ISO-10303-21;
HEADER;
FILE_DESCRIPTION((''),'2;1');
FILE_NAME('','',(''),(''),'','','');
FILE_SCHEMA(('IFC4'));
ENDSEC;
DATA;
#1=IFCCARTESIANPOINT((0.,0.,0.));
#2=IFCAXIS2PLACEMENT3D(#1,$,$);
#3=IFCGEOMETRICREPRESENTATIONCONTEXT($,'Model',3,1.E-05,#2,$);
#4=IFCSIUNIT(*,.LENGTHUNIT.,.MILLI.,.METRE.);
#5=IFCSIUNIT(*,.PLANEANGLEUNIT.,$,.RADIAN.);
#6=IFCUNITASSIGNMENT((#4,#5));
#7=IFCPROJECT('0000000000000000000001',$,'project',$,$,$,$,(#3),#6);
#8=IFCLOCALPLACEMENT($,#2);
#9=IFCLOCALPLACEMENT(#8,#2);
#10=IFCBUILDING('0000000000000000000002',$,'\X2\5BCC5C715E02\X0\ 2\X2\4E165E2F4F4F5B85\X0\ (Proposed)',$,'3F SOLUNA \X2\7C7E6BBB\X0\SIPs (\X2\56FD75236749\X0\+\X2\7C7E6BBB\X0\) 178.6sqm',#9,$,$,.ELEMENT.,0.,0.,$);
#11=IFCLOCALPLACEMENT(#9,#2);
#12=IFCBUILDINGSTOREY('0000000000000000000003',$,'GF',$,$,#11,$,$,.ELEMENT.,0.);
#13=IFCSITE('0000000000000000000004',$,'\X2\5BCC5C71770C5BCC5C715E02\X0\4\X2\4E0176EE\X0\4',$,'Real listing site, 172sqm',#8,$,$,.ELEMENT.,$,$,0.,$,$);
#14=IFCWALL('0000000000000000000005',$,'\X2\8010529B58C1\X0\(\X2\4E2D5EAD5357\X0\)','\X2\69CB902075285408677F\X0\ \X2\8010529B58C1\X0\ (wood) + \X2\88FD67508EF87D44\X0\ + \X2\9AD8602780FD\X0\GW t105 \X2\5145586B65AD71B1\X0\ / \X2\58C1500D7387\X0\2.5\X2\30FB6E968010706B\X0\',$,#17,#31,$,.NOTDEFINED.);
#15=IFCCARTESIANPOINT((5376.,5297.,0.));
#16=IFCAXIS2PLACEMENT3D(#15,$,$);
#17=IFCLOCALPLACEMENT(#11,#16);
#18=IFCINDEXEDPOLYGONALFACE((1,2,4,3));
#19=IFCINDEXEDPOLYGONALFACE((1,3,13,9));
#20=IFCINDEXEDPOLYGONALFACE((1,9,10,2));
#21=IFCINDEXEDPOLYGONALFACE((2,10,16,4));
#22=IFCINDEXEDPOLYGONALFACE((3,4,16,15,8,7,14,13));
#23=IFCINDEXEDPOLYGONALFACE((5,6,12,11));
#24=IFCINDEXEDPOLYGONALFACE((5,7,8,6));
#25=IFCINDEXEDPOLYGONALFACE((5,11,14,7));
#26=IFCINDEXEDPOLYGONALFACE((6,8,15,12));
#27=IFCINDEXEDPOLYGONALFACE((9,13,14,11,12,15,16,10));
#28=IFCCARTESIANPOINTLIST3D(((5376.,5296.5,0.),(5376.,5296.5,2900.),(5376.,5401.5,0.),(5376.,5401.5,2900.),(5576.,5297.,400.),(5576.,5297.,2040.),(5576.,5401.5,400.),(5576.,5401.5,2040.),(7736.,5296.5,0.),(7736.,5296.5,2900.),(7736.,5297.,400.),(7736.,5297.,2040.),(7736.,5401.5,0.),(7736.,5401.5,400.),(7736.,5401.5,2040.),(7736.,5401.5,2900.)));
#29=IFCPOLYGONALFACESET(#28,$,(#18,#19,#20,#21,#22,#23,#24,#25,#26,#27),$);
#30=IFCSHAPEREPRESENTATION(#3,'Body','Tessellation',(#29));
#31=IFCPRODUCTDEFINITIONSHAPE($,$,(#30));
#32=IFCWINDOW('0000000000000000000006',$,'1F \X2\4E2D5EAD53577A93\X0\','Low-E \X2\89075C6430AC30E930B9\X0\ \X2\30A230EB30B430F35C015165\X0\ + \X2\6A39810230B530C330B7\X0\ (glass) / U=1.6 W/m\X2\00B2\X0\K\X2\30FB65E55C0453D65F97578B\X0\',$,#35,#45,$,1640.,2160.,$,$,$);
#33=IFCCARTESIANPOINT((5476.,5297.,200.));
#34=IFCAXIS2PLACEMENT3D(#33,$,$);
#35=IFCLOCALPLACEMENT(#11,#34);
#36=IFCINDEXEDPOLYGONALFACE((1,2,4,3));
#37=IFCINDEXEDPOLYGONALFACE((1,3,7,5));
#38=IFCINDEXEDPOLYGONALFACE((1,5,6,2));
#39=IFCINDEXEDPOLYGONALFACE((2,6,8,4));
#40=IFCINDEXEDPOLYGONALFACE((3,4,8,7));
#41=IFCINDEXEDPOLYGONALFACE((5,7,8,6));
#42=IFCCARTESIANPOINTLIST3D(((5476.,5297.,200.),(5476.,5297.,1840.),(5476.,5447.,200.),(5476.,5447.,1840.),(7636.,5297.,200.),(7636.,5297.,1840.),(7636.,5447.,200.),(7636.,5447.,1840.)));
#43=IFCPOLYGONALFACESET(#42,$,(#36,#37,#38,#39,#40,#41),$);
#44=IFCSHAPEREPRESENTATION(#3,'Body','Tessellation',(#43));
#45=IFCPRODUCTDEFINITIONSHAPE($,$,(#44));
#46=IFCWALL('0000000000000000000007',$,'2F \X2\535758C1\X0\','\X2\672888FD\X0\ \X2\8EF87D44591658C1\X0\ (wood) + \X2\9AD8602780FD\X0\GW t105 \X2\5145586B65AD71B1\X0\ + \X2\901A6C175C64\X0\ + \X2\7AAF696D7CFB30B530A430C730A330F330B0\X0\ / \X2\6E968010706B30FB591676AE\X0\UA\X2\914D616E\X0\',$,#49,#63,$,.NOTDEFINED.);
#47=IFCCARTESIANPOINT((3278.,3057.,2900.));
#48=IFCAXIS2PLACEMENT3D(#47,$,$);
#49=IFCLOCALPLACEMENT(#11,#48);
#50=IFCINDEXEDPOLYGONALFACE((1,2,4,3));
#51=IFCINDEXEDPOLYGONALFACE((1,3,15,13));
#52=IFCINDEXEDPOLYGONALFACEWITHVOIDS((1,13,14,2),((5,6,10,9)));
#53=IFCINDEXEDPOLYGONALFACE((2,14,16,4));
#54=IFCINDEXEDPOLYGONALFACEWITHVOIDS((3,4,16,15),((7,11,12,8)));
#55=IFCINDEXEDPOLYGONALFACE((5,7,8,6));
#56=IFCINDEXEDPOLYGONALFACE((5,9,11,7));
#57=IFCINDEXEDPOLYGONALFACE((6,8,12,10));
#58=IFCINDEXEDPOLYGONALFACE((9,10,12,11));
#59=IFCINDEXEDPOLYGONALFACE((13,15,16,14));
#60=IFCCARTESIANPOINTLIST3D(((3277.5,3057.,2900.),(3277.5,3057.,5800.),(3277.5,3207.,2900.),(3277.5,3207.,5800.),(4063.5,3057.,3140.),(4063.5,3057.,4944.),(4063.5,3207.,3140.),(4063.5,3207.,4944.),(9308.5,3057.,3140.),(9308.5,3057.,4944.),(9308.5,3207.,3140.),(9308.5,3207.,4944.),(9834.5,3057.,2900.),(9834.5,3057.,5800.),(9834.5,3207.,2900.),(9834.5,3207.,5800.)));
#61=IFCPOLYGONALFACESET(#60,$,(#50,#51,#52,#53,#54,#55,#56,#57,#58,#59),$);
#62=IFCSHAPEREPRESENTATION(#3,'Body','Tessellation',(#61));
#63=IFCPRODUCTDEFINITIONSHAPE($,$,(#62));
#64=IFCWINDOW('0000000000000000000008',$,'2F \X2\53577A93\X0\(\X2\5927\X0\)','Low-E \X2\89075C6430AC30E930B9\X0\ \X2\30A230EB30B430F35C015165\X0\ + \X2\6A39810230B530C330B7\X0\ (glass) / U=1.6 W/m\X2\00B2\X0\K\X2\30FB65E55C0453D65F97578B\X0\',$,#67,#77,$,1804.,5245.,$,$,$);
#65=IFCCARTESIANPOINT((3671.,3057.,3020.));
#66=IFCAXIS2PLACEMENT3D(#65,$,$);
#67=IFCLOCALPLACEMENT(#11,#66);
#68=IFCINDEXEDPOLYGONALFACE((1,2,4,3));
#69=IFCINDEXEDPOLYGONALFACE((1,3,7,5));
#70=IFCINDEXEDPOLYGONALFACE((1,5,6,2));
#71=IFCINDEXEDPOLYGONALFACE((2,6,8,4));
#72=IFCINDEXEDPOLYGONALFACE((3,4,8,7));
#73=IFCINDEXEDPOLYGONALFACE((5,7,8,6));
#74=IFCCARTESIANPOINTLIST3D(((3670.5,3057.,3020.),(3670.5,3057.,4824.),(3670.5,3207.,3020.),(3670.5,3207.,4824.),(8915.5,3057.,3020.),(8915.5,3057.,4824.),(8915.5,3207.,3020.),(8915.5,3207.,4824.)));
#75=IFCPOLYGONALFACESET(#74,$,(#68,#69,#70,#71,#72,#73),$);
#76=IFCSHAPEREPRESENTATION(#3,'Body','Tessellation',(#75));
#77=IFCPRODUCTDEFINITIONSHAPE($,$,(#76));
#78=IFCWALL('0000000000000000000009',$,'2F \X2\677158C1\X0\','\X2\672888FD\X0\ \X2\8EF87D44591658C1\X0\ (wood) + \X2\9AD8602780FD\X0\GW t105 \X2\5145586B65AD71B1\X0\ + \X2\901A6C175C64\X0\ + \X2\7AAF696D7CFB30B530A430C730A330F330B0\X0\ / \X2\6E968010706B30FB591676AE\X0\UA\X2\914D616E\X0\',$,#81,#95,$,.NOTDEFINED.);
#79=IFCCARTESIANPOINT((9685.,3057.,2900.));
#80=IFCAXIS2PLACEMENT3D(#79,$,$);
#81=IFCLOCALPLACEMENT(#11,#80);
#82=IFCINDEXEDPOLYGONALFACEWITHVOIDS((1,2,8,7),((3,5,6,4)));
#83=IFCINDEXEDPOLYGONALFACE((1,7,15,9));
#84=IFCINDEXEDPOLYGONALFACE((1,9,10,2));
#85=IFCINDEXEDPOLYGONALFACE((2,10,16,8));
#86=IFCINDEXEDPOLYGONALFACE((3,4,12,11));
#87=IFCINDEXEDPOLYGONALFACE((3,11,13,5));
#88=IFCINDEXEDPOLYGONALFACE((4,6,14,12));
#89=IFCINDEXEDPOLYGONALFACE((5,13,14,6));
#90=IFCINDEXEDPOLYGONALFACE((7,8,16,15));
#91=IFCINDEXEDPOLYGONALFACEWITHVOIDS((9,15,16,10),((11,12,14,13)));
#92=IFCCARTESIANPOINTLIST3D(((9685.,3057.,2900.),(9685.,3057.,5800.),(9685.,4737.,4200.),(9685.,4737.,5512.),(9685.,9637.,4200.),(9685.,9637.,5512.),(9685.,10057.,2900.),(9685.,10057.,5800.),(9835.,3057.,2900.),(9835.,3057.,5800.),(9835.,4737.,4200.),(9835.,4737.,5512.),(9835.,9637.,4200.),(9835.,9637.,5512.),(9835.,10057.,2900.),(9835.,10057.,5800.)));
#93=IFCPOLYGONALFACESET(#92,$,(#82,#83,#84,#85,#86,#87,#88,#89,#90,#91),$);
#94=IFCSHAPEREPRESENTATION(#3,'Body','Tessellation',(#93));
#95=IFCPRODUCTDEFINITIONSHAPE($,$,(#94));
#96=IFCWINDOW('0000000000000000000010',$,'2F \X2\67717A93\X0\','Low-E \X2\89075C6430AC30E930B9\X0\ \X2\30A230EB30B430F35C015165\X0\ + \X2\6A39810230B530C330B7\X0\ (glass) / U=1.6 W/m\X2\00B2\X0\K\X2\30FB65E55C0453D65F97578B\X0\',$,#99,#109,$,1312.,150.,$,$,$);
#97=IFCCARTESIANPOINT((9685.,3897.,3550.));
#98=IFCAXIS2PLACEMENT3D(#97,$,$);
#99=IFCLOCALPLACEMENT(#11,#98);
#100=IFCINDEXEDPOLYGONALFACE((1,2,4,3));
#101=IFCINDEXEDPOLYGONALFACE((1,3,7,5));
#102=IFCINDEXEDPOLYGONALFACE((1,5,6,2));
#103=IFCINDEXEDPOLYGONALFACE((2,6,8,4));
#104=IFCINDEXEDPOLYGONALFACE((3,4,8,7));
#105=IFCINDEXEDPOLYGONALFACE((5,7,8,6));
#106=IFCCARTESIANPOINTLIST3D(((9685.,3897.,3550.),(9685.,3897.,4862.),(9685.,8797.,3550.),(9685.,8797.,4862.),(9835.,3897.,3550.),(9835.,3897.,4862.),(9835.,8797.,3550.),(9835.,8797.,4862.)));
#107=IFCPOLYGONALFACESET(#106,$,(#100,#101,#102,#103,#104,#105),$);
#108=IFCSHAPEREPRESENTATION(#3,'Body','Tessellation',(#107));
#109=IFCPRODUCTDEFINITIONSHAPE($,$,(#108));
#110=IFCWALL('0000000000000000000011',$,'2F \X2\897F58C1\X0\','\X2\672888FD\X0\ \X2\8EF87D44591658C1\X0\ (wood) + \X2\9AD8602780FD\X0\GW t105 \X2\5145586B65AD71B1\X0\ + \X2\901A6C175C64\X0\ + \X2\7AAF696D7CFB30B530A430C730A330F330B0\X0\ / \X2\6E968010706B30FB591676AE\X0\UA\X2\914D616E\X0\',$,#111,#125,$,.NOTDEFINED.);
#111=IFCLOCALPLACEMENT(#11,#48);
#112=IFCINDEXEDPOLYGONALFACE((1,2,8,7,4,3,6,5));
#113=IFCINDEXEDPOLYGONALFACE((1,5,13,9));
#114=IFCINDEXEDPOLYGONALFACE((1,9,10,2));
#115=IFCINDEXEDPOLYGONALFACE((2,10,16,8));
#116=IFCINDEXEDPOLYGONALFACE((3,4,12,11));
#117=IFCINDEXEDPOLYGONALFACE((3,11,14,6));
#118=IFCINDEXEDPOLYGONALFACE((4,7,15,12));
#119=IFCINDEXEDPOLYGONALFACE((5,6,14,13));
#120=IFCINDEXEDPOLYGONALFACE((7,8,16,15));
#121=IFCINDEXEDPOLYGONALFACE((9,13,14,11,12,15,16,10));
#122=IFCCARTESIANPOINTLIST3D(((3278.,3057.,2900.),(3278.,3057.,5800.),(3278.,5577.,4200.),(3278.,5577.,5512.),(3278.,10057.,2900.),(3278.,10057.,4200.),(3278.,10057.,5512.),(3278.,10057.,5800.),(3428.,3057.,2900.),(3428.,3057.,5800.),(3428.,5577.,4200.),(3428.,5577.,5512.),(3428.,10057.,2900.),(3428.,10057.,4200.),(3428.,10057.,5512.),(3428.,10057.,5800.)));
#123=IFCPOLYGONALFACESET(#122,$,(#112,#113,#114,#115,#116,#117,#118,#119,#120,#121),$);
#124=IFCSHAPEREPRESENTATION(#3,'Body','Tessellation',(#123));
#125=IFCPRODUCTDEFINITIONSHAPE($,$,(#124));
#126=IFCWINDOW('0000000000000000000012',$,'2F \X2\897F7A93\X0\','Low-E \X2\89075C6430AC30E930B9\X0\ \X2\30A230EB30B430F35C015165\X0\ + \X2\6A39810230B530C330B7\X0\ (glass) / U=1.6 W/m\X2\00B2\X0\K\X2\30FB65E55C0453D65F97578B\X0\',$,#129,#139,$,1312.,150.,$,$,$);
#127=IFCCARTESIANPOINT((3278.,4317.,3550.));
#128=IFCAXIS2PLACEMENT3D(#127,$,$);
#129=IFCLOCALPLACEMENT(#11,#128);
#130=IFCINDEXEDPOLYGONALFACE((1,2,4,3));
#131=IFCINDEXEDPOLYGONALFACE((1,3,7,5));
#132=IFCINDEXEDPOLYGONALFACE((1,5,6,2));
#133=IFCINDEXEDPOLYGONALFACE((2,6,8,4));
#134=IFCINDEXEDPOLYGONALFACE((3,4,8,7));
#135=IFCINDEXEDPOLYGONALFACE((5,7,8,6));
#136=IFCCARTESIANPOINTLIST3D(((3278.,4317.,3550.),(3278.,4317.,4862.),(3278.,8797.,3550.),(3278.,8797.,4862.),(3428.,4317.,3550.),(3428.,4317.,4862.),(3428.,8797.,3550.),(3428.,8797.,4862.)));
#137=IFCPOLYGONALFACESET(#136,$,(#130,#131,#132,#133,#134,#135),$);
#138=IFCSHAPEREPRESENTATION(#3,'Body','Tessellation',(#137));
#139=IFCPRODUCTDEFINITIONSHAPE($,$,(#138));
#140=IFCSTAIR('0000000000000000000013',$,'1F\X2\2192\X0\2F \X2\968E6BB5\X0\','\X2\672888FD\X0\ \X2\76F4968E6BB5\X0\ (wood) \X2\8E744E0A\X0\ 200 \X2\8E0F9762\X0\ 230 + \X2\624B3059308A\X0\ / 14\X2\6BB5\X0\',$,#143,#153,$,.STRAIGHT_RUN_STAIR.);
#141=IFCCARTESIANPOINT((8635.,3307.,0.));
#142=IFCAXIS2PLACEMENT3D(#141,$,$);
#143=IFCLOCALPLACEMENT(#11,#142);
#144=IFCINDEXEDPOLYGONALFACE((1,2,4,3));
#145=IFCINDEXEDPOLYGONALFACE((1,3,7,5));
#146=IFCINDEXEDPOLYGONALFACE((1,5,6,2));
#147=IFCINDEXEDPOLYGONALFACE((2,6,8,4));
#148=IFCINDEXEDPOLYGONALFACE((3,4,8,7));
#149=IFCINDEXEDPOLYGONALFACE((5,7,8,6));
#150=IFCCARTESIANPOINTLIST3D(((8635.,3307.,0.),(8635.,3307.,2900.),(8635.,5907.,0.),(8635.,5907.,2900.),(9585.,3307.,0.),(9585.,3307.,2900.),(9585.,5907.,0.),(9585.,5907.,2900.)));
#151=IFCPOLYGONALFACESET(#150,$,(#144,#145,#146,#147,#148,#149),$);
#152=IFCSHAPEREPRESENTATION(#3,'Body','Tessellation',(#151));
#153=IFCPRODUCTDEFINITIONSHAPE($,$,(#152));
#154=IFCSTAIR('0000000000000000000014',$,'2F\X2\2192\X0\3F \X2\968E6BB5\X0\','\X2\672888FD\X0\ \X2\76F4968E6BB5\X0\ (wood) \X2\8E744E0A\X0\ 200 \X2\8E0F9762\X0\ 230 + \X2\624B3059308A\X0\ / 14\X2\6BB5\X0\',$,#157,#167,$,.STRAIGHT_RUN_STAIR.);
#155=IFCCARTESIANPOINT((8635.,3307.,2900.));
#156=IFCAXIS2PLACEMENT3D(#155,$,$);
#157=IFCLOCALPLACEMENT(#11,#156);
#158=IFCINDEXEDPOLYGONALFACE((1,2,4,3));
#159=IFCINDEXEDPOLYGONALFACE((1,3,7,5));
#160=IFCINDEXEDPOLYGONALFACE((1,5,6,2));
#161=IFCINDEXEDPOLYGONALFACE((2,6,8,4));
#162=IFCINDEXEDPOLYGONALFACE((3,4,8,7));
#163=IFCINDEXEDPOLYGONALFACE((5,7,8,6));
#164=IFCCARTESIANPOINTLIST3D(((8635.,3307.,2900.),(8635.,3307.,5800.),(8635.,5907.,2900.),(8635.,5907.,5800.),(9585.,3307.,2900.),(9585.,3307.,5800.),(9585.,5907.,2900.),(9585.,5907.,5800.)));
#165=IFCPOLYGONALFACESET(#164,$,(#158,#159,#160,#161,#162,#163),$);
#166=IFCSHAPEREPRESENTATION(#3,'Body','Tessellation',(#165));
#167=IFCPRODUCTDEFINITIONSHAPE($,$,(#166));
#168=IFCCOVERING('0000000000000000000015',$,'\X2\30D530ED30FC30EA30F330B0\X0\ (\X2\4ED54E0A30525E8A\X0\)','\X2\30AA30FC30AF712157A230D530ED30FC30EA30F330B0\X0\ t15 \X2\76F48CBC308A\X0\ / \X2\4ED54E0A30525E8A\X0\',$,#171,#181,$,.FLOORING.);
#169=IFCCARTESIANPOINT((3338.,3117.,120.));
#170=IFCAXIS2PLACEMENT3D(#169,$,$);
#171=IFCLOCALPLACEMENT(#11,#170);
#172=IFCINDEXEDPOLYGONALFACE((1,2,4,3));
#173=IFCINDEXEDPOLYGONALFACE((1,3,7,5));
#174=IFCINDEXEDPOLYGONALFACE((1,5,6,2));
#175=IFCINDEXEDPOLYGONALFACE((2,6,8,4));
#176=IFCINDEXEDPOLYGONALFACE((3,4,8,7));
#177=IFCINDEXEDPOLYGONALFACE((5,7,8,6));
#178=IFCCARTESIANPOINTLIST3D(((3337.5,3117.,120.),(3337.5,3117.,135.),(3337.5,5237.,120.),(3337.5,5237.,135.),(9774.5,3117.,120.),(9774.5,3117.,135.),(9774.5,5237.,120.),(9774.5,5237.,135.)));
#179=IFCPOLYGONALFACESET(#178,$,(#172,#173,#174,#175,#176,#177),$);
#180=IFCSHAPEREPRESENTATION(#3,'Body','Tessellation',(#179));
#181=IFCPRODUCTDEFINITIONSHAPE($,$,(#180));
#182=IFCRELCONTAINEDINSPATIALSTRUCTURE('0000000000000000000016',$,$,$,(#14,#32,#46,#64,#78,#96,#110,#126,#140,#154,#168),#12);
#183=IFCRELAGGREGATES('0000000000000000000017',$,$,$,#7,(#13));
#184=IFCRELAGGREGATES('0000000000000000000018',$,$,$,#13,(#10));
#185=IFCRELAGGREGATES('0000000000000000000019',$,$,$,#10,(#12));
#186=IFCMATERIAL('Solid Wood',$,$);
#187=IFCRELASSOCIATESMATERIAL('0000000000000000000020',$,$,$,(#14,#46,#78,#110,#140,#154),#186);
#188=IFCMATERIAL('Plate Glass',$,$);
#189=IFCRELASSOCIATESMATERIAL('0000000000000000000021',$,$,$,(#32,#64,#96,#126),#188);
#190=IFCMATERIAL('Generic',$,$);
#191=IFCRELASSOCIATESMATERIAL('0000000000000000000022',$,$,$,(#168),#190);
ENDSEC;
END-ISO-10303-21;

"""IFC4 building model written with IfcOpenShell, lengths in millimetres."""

from ifc_helpers import new_model, si_unit, frame, frame_2d, origin, place, context, project, spatial, rectangle, extrude, material, element, fill, save


model = new_model("IFC4")

# Units and contexts
model_context = context("Model", 3, precision=1e-05, world=origin())
ifc_project = project(units=[si_unit("LENGTHUNIT", "METRE", prefix="MILLI"), si_unit("PLANEANGLEUNIT", "RADIAN")], contexts=[model_context])

# Site, building, storey
site_placement = place(None, origin())
site = spatial("IfcSite", under=ifc_project, at=site_placement, Name="富山県富山市4丁目4", ObjectType="Real listing site, 172sqm", CompositionType="ELEMENT", RefElevation=0.0)
building_placement = place(site_placement, origin())
building = spatial("IfcBuilding", under=site, at=building_placement, Name="富山市 2世帯住宅 (Proposed)", ObjectType="3F SOLUNA 籾殻SIPs (国産杉+籾殻) 178.6sqm", CompositionType="ELEMENT", ElevationOfRefHeight=0.0, ElevationOfTerrain=0.0)
storey_placement = place(building_placement, origin())
storey = spatial("IfcBuildingStorey", under=building, at=storey_placement, Name="GF", CompositionType="ELEMENT", Elevation=0.0)

# Shared definitions
ifc_material_1 = material(Name="Solid Wood")
ifc_material_2 = material(Name="Generic")

# Shared definitions
ifc_material_3 = material(Name="Plate Glass")

# Walls, openings, windows
wall_1_placement = place(storey_placement, frame((5376.0, 5297.0, 0.0)))
wall_1 = element("IfcWall", 1, at=wall_1_placement, inside=storey, material=ifc_material_1, Name="耐力壁(中庭南)", Description="構造用合板 耐力壁 (wood) + 製材軸組 + 高性能GW t105 充填断熱 / 壁倍率2.5・準耐火", PredefinedType="NOTDEFINED", context=model_context, shape_type="SweptSolid", body=[
    extrude(rectangle(XDim=2360.0, YDim=105.0, at=frame_2d((1180.0, 52.0))), frame((5376.0, 5297.0, 0.0)), (0.0, 0.0, 1.0), 2900.0),
])
opening_1_placement = place(storey_placement, frame((5476.0, 5297.0, 200.0)))
opening_1 = element("IfcOpeningElement", 2, at=opening_1_placement, cuts=wall_1, PredefinedType="NOTDEFINED", context=model_context, shape_type="SweptSolid", body=[
    extrude(rectangle(XDim=2160.0, YDim=150.0, at=frame_2d((1080.0, 75.0))), frame((5476.0, 5297.0, 200.0)), (0.0, 0.0, 1.0), 1640.0),
])
window_1_placement = place(storey_placement, frame((5476.0, 5297.0, 200.0)))
window_1 = element("IfcWindow", 3, at=window_1_placement, inside=storey, material=ifc_material_3, Name="1F 中庭南窓", Description="Low-E 複層ガラス アルゴン封入 + 樹脂サッシ (glass) / U=1.6 W/m²K・日射取得型", OverallHeight=1640.0, OverallWidth=2160.0, context=model_context, shape_type="SweptSolid", body=[
    extrude(rectangle(XDim=2160.0, YDim=150.0, at=frame_2d((1080.0, 75.0))), frame((5476.0, 5297.0, 200.0)), (0.0, 0.0, 1.0), 1640.0),
])
fill(opening_1, window_1)
wall_2_placement = place(storey_placement, frame((3278.0, 3057.0, 2900.0)))
wall_2 = element("IfcWall", 4, at=wall_2_placement, inside=storey, material=ifc_material_1, Name="2F 南壁", Description="木製 軸組外壁 (wood) + 高性能GW t105 充填断熱 + 通気層 + 窯業系サイディング / 準耐火・外皮UA配慮", PredefinedType="NOTDEFINED", context=model_context, shape_type="SweptSolid", body=[
    extrude(rectangle(XDim=6557.0, YDim=150.0, at=frame_2d((3278.0, 75.0))), frame((3278.0, 3057.0, 2900.0)), (0.0, 0.0, 1.0), 2900.0),
])
opening_2_placement = place(storey_placement, frame((3671.0, 3057.0, 3020.0)))
opening_2 = element("IfcOpeningElement", 5, at=opening_2_placement, cuts=wall_2, PredefinedType="NOTDEFINED", context=model_context, shape_type="SweptSolid", body=[
    extrude(rectangle(XDim=5245.0, YDim=150.0, at=frame_2d((2622.0, 75.0))), frame((3671.0, 3057.0, 3020.0)), (0.0, 0.0, 1.0), 1804.0),
])
window_2_placement = place(storey_placement, frame((3671.0, 3057.0, 3020.0)))
window_2 = element("IfcWindow", 6, at=window_2_placement, inside=storey, material=ifc_material_3, Name="2F 南窓(大)", Description="Low-E 複層ガラス アルゴン封入 + 樹脂サッシ (glass) / U=1.6 W/m²K・日射取得型", OverallHeight=1804.0, OverallWidth=5245.0, context=model_context, shape_type="SweptSolid", body=[
    extrude(rectangle(XDim=5245.0, YDim=150.0, at=frame_2d((2622.0, 75.0))), frame((3671.0, 3057.0, 3020.0)), (0.0, 0.0, 1.0), 1804.0),
])
fill(opening_2, window_2)
wall_3_placement = place(storey_placement, frame((9685.0, 3057.0, 2900.0)))
wall_3 = element("IfcWall", 7, at=wall_3_placement, inside=storey, material=ifc_material_1, Name="2F 東壁", Description="木製 軸組外壁 (wood) + 高性能GW t105 充填断熱 + 通気層 + 窯業系サイディング / 準耐火・外皮UA配慮", PredefinedType="NOTDEFINED", context=model_context, shape_type="SweptSolid", body=[
    extrude(rectangle(XDim=150.0, YDim=7000.0, at=frame_2d((75.0, 3500.0))), frame((9685.0, 3057.0, 2900.0)), (0.0, 0.0, 1.0), 2900.0),
])
opening_3_placement = place(storey_placement, frame((9685.0, 3897.0, 3550.0)))
opening_3 = element("IfcOpeningElement", 8, at=opening_3_placement, cuts=wall_3, PredefinedType="NOTDEFINED", context=model_context, shape_type="SweptSolid", body=[
    extrude(rectangle(XDim=150.0, YDim=4900.0, at=frame_2d((75.0, 2450.0))), frame((9685.0, 3897.0, 3550.0)), (0.0, 0.0, 1.0), 1312.0),
])
window_3_placement = place(storey_placement, frame((9685.0, 3897.0, 3550.0)))
window_3 = element("IfcWindow", 9, at=window_3_placement, inside=storey, material=ifc_material_3, Name="2F 東窓", Description="Low-E 複層ガラス アルゴン封入 + 樹脂サッシ (glass) / U=1.6 W/m²K・日射取得型", OverallHeight=1312.0, OverallWidth=150.0, context=model_context, shape_type="SweptSolid", body=[
    extrude(rectangle(XDim=150.0, YDim=4900.0, at=frame_2d((75.0, 2450.0))), frame((9685.0, 3897.0, 3550.0)), (0.0, 0.0, 1.0), 1312.0),
])
fill(opening_3, window_3)
wall_4_placement = place(storey_placement, frame((3278.0, 3057.0, 2900.0)))
wall_4 = element("IfcWall", 10, at=wall_4_placement, inside=storey, material=ifc_material_1, Name="2F 西壁", Description="木製 軸組外壁 (wood) + 高性能GW t105 充填断熱 + 通気層 + 窯業系サイディング / 準耐火・外皮UA配慮", PredefinedType="NOTDEFINED", context=model_context, shape_type="SweptSolid", body=[
    extrude(rectangle(XDim=150.0, YDim=7000.0, at=frame_2d((75.0, 3500.0))), frame((3278.0, 3057.0, 2900.0)), (0.0, 0.0, 1.0), 2900.0),
])
opening_4_placement = place(storey_placement, frame((3278.0, 4317.0, 3550.0)))
opening_4 = element("IfcOpeningElement", 11, at=opening_4_placement, cuts=wall_4, PredefinedType="NOTDEFINED", context=model_context, shape_type="SweptSolid", body=[
    extrude(rectangle(XDim=150.0, YDim=4480.0, at=frame_2d((75.0, 2240.0))), frame((3278.0, 4317.0, 3550.0)), (0.0, 0.0, 1.0), 1312.0),
])
window_4_placement = place(storey_placement, frame((3278.0, 4317.0, 3550.0)))
window_4 = element("IfcWindow", 12, at=window_4_placement, inside=storey, material=ifc_material_3, Name="2F 西窓", Description="Low-E 複層ガラス アルゴン封入 + 樹脂サッシ (glass) / U=1.6 W/m²K・日射取得型", OverallHeight=1312.0, OverallWidth=150.0, context=model_context, shape_type="SweptSolid", body=[
    extrude(rectangle(XDim=150.0, YDim=4480.0, at=frame_2d((75.0, 2240.0))), frame((3278.0, 4317.0, 3550.0)), (0.0, 0.0, 1.0), 1312.0),
])
fill(opening_4, window_4)

# Stairs
stair_1_placement = place(storey_placement, frame((8635.0, 3307.0, 0.0)))
element("IfcStair", 13, at=stair_1_placement, inside=storey, material=ifc_material_1, Name="1F→2F 階段", Description="木製 直階段 (wood) 蹴上 200 踏面 230 + 手すり / 14段", PredefinedType="STRAIGHT_RUN_STAIR", context=model_context, shape_type="SweptSolid", body=[
    extrude(rectangle(XDim=950.0, YDim=2600.0, at=frame_2d((475.0, 1300.0))), frame((8635.0, 3307.0, 0.0)), (0.0, 0.0, 1.0), 2900.0),
])
stair_2_placement = place(storey_placement, frame((8635.0, 3307.0, 2900.0)))
element("IfcStair", 14, at=stair_2_placement, inside=storey, material=ifc_material_1, Name="2F→3F 階段", Description="木製 直階段 (wood) 蹴上 200 踏面 230 + 手すり / 14段", PredefinedType="STRAIGHT_RUN_STAIR", context=model_context, shape_type="SweptSolid", body=[
    extrude(rectangle(XDim=950.0, YDim=2600.0, at=frame_2d((475.0, 1300.0))), frame((8635.0, 3307.0, 2900.0)), (0.0, 0.0, 1.0), 2900.0),
])

# Covering
covering_placement = place(storey_placement, frame((3338.0, 3117.0, 120.0)))
element("IfcCovering", 15, at=covering_placement, inside=storey, material=ifc_material_2, Name="フローリング (仕上げ床)", Description="オーク無垢フローリング t15 直貼り / 仕上げ床", PredefinedType="FLOORING", context=model_context, shape_type="SweptSolid", body=[
    extrude(rectangle(XDim=6437.0, YDim=2120.0, at=frame_2d((3218.0, 1060.0))), frame((3338.0, 3117.0, 120.0)), (0.0, 0.0, 1.0), 15.0),
])

save(model, "model.ifc")
